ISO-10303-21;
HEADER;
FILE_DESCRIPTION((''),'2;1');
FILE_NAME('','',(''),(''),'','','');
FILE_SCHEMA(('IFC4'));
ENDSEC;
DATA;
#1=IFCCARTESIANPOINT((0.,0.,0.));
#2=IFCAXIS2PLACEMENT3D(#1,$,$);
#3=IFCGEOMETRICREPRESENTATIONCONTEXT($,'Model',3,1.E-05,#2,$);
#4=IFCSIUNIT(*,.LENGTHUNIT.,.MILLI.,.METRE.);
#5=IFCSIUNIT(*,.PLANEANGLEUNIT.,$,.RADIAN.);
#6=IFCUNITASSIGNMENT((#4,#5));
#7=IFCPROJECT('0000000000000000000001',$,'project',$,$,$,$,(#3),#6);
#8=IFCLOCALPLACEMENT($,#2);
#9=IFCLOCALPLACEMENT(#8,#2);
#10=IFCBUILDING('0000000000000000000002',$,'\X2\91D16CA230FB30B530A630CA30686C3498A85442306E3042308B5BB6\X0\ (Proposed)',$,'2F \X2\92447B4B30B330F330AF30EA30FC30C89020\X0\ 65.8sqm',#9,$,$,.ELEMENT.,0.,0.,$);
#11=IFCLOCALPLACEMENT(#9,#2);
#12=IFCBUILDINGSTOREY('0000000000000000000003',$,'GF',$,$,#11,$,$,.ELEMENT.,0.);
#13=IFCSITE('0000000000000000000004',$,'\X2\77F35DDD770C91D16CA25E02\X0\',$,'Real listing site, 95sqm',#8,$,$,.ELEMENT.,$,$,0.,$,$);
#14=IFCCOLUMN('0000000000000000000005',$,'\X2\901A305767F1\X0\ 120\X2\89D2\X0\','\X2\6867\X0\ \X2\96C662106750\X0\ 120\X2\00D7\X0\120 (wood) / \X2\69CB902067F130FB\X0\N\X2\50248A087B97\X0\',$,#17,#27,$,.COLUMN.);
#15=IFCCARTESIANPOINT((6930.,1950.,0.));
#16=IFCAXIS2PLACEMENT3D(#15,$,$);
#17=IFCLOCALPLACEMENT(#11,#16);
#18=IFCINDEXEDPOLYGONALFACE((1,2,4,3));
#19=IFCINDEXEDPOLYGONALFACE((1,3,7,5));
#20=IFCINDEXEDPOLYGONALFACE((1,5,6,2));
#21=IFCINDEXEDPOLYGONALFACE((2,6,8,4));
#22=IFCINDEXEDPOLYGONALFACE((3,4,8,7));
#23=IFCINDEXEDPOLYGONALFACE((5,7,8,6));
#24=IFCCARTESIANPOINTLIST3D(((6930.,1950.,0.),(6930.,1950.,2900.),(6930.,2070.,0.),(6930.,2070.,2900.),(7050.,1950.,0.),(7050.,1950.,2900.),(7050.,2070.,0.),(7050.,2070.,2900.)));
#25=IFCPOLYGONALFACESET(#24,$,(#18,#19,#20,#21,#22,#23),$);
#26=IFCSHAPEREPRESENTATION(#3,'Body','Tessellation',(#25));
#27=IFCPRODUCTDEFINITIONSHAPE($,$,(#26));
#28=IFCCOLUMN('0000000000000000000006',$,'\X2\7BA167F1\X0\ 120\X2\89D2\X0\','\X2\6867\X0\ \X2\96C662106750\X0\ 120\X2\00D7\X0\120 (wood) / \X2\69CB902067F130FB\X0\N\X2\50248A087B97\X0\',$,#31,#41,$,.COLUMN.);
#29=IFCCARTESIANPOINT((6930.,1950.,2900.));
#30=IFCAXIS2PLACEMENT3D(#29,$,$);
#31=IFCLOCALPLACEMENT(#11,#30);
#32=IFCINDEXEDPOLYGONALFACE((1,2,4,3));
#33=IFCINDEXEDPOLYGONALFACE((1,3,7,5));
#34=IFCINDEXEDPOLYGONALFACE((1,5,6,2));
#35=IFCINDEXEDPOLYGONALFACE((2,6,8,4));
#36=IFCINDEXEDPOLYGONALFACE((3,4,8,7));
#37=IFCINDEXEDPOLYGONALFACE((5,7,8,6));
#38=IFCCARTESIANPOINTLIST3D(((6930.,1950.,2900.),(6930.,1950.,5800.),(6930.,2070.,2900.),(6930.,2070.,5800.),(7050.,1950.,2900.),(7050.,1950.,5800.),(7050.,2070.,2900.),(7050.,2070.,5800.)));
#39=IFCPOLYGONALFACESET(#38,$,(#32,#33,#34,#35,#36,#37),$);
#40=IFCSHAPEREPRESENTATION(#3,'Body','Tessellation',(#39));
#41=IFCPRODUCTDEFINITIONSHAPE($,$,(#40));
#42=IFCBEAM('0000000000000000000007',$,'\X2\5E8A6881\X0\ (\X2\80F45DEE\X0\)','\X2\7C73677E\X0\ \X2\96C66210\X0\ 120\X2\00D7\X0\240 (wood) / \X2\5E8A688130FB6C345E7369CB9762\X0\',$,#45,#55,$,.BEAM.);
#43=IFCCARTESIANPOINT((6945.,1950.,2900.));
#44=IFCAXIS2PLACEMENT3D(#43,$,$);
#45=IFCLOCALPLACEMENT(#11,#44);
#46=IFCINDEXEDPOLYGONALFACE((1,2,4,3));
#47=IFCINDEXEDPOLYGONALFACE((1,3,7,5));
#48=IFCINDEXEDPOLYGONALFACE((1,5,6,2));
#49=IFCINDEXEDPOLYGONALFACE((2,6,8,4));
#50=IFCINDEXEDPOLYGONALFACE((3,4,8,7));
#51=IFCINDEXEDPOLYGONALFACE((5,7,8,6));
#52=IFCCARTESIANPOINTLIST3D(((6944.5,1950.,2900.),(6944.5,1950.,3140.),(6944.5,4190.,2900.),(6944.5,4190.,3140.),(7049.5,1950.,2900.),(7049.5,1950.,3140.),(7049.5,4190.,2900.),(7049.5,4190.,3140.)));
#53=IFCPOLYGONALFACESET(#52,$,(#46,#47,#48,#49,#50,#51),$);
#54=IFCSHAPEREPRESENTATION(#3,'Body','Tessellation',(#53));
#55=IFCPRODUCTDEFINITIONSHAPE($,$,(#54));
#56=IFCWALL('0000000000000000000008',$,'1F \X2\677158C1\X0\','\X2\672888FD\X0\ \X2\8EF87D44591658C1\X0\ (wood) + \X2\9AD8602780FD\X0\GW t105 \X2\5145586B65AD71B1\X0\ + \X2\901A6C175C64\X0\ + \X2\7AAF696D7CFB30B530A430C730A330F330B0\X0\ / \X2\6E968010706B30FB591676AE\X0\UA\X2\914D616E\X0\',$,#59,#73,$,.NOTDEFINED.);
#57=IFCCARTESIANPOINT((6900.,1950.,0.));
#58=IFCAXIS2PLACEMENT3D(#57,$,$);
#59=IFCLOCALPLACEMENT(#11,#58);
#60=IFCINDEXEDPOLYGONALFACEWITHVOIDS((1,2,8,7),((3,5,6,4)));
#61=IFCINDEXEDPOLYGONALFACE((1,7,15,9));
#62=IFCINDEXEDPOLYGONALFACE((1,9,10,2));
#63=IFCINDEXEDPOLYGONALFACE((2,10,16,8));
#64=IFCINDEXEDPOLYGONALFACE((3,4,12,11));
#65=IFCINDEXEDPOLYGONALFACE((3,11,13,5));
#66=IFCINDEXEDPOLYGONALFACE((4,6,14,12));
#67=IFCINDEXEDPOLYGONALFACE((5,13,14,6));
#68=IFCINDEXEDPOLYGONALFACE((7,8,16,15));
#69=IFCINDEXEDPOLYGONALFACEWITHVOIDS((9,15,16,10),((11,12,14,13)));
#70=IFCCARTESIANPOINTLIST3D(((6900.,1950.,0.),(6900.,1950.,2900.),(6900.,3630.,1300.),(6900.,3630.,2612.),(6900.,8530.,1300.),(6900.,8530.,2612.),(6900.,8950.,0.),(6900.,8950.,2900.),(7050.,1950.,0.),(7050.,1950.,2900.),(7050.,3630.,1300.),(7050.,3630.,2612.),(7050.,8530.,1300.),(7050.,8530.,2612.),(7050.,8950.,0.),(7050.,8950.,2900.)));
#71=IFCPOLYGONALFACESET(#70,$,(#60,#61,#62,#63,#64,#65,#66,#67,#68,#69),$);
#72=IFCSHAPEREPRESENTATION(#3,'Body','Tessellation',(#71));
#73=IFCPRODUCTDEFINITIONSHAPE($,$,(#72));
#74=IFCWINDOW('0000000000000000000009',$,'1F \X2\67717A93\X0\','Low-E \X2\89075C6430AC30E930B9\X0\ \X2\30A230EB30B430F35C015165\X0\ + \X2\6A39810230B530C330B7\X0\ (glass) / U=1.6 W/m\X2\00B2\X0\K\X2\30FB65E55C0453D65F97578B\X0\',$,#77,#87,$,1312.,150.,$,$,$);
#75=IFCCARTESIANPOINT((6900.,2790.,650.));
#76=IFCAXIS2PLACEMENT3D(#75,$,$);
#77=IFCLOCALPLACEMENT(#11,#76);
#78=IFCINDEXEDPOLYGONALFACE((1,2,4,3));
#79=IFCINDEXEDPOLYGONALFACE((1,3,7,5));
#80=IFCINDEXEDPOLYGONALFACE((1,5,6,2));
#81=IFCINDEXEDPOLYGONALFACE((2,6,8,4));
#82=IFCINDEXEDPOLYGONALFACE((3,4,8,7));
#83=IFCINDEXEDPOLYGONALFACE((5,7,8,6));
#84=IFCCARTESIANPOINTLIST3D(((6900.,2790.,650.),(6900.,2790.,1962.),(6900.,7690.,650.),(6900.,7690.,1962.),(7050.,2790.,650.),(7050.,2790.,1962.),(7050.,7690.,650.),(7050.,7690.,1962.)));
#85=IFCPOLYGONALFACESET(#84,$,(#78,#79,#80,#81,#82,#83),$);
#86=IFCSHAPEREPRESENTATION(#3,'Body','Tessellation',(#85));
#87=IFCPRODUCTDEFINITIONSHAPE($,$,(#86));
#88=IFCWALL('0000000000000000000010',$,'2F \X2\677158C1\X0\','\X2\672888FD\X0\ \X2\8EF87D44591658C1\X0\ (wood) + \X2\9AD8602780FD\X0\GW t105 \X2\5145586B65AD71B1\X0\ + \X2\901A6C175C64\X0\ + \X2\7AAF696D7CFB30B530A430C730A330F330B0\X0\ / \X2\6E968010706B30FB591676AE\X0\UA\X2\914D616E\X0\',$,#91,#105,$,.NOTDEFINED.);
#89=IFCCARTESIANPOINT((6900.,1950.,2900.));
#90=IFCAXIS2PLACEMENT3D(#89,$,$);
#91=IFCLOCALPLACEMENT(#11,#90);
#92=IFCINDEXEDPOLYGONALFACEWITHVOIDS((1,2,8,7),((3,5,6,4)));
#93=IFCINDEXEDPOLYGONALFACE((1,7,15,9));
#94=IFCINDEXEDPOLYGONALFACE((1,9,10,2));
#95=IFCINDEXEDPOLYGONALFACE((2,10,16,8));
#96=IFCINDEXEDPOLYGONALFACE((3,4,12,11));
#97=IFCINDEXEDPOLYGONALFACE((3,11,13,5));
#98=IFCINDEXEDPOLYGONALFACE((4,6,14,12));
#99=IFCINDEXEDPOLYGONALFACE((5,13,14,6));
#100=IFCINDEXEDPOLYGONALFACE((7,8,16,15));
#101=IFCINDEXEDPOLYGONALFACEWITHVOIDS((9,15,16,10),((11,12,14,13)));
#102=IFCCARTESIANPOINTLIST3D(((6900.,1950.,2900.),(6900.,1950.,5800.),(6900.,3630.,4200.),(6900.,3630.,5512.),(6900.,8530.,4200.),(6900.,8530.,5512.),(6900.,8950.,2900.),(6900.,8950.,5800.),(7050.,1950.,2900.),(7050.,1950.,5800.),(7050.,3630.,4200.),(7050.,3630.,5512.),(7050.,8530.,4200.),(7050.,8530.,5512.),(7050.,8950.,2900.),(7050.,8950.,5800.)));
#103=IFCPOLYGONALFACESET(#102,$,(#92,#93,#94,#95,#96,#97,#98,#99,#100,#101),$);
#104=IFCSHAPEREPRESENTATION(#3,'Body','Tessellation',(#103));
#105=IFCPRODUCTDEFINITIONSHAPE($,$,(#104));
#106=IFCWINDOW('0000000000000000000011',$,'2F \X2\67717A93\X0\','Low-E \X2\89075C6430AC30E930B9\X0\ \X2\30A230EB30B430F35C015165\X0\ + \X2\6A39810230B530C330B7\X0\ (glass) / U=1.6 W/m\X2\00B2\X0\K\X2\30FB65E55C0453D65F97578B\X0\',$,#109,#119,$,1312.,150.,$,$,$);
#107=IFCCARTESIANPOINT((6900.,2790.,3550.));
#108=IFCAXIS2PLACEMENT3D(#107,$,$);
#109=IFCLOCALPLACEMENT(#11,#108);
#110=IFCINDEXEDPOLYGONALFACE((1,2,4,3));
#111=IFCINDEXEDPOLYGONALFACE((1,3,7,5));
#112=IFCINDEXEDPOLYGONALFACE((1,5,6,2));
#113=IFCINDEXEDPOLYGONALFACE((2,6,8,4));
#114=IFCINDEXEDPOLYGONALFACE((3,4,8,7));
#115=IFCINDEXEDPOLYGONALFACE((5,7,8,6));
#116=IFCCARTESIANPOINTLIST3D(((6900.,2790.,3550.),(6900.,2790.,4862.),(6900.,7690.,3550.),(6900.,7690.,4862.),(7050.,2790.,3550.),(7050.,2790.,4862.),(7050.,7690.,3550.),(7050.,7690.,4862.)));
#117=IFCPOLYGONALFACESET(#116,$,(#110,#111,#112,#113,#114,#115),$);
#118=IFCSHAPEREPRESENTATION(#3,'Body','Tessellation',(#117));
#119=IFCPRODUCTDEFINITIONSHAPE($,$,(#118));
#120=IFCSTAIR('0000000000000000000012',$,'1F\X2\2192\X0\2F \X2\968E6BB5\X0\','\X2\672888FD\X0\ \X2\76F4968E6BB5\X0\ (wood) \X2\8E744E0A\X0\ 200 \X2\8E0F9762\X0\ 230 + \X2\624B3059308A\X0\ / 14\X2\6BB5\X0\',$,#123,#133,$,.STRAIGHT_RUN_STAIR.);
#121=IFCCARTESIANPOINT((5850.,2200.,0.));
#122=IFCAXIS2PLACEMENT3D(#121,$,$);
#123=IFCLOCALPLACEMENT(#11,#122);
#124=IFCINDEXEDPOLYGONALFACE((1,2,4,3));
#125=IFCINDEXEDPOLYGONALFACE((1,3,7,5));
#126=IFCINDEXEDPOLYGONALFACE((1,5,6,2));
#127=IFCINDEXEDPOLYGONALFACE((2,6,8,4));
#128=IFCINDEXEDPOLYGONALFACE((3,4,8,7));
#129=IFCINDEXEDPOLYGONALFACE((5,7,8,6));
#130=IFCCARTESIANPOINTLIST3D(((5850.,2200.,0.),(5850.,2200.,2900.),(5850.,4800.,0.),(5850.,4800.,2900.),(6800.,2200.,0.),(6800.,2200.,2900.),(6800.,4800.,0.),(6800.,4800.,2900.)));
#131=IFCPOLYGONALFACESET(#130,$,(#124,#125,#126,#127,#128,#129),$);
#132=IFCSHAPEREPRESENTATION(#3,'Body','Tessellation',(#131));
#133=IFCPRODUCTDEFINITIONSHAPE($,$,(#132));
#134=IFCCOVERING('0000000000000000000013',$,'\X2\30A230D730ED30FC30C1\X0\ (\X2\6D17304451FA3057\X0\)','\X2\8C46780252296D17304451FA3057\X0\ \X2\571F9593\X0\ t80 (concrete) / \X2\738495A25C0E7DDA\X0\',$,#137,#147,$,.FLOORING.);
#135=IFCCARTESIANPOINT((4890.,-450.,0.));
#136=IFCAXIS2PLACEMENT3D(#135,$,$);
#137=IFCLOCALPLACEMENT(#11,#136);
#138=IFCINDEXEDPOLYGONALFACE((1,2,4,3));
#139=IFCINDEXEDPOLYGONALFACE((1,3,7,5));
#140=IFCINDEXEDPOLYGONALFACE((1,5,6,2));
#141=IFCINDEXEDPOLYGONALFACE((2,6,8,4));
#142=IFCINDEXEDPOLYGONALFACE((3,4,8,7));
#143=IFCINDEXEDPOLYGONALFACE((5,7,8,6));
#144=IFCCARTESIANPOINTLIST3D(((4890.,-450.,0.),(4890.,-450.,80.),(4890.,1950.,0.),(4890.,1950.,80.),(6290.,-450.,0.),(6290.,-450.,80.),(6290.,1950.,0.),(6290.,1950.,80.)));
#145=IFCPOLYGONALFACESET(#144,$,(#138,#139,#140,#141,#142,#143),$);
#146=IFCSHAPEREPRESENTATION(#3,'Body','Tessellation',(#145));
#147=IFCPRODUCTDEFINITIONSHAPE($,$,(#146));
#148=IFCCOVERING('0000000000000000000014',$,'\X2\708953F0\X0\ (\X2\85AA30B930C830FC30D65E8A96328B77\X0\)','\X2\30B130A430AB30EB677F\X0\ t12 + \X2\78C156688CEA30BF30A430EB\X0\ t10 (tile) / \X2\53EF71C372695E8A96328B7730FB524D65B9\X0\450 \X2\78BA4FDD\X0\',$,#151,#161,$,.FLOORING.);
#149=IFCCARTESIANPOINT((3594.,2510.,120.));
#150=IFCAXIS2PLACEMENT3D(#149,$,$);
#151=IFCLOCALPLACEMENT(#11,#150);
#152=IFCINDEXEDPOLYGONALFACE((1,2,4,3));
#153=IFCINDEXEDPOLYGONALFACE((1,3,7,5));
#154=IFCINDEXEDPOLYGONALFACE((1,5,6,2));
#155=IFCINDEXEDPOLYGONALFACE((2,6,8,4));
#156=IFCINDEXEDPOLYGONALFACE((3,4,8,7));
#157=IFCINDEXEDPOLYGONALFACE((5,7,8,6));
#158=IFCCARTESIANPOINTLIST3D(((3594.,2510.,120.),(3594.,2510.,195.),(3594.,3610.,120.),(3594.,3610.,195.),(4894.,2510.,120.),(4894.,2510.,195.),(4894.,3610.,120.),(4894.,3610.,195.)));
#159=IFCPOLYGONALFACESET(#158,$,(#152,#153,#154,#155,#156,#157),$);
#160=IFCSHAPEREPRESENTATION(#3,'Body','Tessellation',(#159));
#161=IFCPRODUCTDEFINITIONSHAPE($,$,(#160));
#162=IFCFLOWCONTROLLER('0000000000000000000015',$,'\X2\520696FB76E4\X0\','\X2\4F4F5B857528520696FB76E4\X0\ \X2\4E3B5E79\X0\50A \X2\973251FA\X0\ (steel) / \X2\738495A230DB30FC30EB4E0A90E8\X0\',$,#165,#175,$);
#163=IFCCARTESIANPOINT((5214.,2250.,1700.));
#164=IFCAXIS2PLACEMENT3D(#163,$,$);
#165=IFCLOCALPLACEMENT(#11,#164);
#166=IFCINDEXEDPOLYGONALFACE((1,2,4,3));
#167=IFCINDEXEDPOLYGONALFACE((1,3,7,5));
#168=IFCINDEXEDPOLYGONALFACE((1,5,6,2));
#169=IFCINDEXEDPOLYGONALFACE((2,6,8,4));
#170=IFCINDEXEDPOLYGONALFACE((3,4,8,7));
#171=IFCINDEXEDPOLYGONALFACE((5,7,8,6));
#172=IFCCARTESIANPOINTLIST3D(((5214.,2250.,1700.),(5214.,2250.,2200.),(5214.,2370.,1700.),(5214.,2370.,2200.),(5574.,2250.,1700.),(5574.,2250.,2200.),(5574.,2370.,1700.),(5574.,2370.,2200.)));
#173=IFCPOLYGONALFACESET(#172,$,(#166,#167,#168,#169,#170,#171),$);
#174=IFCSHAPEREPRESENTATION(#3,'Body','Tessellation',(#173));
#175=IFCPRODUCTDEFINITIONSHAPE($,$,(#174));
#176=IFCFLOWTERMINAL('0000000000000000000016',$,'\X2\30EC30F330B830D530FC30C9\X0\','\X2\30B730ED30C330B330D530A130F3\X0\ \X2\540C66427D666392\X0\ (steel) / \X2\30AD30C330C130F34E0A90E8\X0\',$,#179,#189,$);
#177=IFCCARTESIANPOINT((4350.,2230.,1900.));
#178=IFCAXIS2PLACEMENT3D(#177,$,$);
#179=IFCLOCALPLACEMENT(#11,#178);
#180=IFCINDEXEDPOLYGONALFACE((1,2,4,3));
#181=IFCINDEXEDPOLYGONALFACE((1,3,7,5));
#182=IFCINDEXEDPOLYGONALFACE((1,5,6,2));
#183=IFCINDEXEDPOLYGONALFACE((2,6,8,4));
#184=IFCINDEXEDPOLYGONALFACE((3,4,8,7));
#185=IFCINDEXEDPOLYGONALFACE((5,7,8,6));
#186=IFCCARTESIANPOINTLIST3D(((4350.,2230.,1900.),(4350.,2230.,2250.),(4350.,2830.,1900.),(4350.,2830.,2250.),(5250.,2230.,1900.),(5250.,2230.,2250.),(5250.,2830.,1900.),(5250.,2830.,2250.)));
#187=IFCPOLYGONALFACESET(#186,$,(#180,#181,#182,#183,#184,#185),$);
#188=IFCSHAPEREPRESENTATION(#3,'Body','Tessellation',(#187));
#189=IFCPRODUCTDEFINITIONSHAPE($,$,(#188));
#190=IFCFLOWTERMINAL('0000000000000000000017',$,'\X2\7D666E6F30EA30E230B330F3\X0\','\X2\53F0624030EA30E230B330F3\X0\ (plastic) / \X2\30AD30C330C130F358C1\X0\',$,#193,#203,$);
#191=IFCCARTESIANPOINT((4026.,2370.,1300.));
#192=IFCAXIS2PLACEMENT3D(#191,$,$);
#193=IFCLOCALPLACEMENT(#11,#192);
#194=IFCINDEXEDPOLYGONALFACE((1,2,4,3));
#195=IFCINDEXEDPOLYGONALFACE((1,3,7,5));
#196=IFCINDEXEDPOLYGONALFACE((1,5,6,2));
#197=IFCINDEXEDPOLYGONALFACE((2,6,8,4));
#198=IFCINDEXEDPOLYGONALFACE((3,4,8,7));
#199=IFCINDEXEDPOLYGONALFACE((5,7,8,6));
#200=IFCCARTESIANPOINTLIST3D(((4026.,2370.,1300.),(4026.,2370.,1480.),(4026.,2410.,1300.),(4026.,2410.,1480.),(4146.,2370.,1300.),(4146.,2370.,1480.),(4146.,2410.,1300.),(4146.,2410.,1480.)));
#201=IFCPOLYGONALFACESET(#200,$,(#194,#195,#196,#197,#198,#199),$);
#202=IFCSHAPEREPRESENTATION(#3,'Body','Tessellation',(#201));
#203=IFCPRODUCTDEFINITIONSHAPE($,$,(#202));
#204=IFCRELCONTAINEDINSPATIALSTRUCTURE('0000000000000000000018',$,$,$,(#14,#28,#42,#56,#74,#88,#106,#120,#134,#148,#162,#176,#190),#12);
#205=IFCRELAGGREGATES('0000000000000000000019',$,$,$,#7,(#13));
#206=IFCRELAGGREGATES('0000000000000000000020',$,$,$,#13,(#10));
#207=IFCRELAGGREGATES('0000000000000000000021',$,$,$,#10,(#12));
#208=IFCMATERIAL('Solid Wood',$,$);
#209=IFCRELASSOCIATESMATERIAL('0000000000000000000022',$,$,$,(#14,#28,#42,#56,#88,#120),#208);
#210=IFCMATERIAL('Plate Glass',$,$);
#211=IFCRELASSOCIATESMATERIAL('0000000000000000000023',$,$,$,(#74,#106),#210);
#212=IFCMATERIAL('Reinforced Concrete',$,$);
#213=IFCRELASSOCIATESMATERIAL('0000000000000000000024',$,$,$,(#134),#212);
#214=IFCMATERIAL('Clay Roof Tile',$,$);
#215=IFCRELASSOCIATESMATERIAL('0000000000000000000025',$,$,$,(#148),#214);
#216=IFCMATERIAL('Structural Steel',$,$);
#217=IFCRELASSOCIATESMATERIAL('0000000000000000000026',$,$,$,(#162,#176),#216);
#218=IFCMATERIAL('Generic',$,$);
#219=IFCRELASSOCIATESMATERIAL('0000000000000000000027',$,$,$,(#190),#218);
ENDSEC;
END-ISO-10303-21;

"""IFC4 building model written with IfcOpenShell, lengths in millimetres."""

from ifc_helpers import new_model, si_unit, frame, frame_2d, origin, place, context, project, spatial, rectangle, extrude, material, element, fill, save


model = new_model("IFC4")

# Units and contexts
model_context = context("Model", 3, precision=1e-05, world=origin())
ifc_project = project(units=[si_unit("LENGTHUNIT", "METRE", prefix="MILLI"), si_unit("PLANEANGLEUNIT", "RADIAN")], contexts=[model_context])

# Site, building, storey
site_placement = place(None, origin())
site = spatial("IfcSite", under=ifc_project, at=site_placement, Name="石川県金沢市", ObjectType="Real listing site, 95sqm", CompositionType="ELEMENT", RefElevation=0.0)
building_placement = place(site_placement, origin())
building = spatial("IfcBuilding", under=site, at=building_placement, Name="金沢・サウナと水風呂のある家 (Proposed)", ObjectType="2F 鉄筋コンクリート造 65.8sqm", CompositionType="ELEMENT", ElevationOfRefHeight=0.0, ElevationOfTerrain=0.0)
storey_placement = place(building_placement, origin())
storey = spatial("IfcBuildingStorey", under=building, at=storey_placement, Name="GF", CompositionType="ELEMENT", Elevation=0.0)

# Columns
ifc_material_1 = material(Name="Solid Wood")
column_1_placement = place(storey_placement, frame((6930.0, 1950.0, 0.0)))
element("IfcColumn", 1, at=column_1_placement, inside=storey, material=ifc_material_1, Name="通し柱 120角", Description="桧 集成材 120×120 (wood) / 構造柱・N値計算", PredefinedType="COLUMN", context=model_context, shape_type="SweptSolid", body=[
    extrude(rectangle(XDim=120.0, YDim=120.0, at=frame_2d((60.0, 60.0))), frame((6930.0, 1950.0, 0.0)), (0.0, 0.0, 1.0), 2900.0),
])
column_2_placement = place(storey_placement, frame((6930.0, 1950.0, 2900.0)))
element("IfcColumn", 2, at=column_2_placement, inside=storey, material=ifc_material_1, Name="管柱 120角", Description="桧 集成材 120×120 (wood) / 構造柱・N値計算", PredefinedType="COLUMN", context=model_context, shape_type="SweptSolid", body=[
    extrude(rectangle(XDim=120.0, YDim=120.0, at=frame_2d((60.0, 60.0))), frame((6930.0, 1950.0, 2900.0)), (0.0, 0.0, 1.0), 2900.0),
])

# Beam
beam_1_placement = place(storey_placement, frame((6945.0, 1950.0, 2900.0)))
element("IfcBeam", 3, at=beam_1_placement, inside=storey, material=ifc_material_1, Name="床梁 (胴差)", Description="米松 集成 120×240 (wood) / 床梁・水平構面", PredefinedType="BEAM", context=model_context, shape_type="SweptSolid", body=[
    extrude(rectangle(XDim=105.0, YDim=2240.0, at=frame_2d((52.0, 1120.0))), frame((6945.0, 1950.0, 2900.0)), (0.0, 0.0, 1.0), 240.0),
])

# Wall, opening, window
wall_1_placement = place(storey_placement, frame((6900.0, 1950.0, 0.0)))
wall_1 = element("IfcWall", 4, at=wall_1_placement, inside=storey, material=ifc_material_1, Name="1F 東壁", Description="木製 軸組外壁 (wood) + 高性能GW t105 充填断熱 + 通気層 + 窯業系サイディング / 準耐火・外皮UA配慮", PredefinedType="NOTDEFINED", context=model_context, shape_type="SweptSolid", body=[
    extrude(rectangle(XDim=150.0, YDim=7000.0, at=frame_2d((75.0, 3500.0))), frame((6900.0, 1950.0, 0.0)), (0.0, 0.0, 1.0), 2900.0),
])
opening_1_placement = place(storey_placement, frame((6900.0, 2790.0, 650.0)))
opening_1 = element("IfcOpeningElement", 5, at=opening_1_placement, cuts=wall_1, PredefinedType="NOTDEFINED", context=model_context, shape_type="SweptSolid", body=[
    extrude(rectangle(XDim=150.0, YDim=4900.0, at=frame_2d((75.0, 2450.0))), frame((6900.0, 2790.0, 650.0)), (0.0, 0.0, 1.0), 1312.0),
])
ifc_material_2 = material(Name="Plate Glass")
window_1_placement = place(storey_placement, frame((6900.0, 2790.0, 650.0)))
window_1 = element("IfcWindow", 6, at=window_1_placement, inside=storey, material=ifc_material_2, Name="1F 東窓", Description="Low-E 複層ガラス アルゴン封入 + 樹脂サッシ (glass) / U=1.6 W/m²K・日射取得型", OverallHeight=1312.0, OverallWidth=150.0, context=model_context, shape_type="SweptSolid", body=[
    extrude(rectangle(XDim=150.0, YDim=4900.0, at=frame_2d((75.0, 2450.0))), frame((6900.0, 2790.0, 650.0)), (0.0, 0.0, 1.0), 1312.0),
])
fill(opening_1, window_1)

# Wall, opening, window
wall_2_placement = place(storey_placement, frame((6900.0, 1950.0, 2900.0)))
wall_2 = element("IfcWall", 7, at=wall_2_placement, inside=storey, material=ifc_material_1, Name="2F 東壁", Description="木製 軸組外壁 (wood) + 高性能GW t105 充填断熱 + 通気層 + 窯業系サイディング / 準耐火・外皮UA配慮", PredefinedType="NOTDEFINED", context=model_context, shape_type="SweptSolid", body=[
    extrude(rectangle(XDim=150.0, YDim=7000.0, at=frame_2d((75.0, 3500.0))), frame((6900.0, 1950.0, 2900.0)), (0.0, 0.0, 1.0), 2900.0),
])
opening_2_placement = place(storey_placement, frame((6900.0, 2790.0, 3550.0)))
opening_2 = element("IfcOpeningElement", 8, at=opening_2_placement, cuts=wall_2, PredefinedType="NOTDEFINED", context=model_context, shape_type="SweptSolid", body=[
    extrude(rectangle(XDim=150.0, YDim=4900.0, at=frame_2d((75.0, 2450.0))), frame((6900.0, 2790.0, 3550.0)), (0.0, 0.0, 1.0), 1312.0),
])
window_2_placement = place(storey_placement, frame((6900.0, 2790.0, 3550.0)))
window_2 = element("IfcWindow", 9, at=window_2_placement, inside=storey, material=ifc_material_2, Name="2F 東窓", Description="Low-E 複層ガラス アルゴン封入 + 樹脂サッシ (glass) / U=1.6 W/m²K・日射取得型", OverallHeight=1312.0, OverallWidth=150.0, context=model_context, shape_type="SweptSolid", body=[
    extrude(rectangle(XDim=150.0, YDim=4900.0, at=frame_2d((75.0, 2450.0))), frame((6900.0, 2790.0, 3550.0)), (0.0, 0.0, 1.0), 1312.0),
])
fill(opening_2, window_2)

# Stair
stair_placement = place(storey_placement, frame((5850.0, 2200.0, 0.0)))
element("IfcStair", 10, at=stair_placement, inside=storey, material=ifc_material_1, Name="1F→2F 階段", Description="木製 直階段 (wood) 蹴上 200 踏面 230 + 手すり / 14段", PredefinedType="STRAIGHT_RUN_STAIR", context=model_context, shape_type="SweptSolid", body=[
    extrude(rectangle(XDim=950.0, YDim=2600.0, at=frame_2d((475.0, 1300.0))), frame((5850.0, 2200.0, 0.0)), (0.0, 0.0, 1.0), 2900.0),
])

# Coverings
ifc_material_3 = material(Name="Reinforced Concrete")
covering_1_placement = place(storey_placement, frame((4890.0, -450.0, 0.0)))
element("IfcCovering", 11, at=covering_1_placement, inside=storey, material=ifc_material_3, Name="アプローチ (洗い出し)", Description="豆砂利洗い出し 土間 t80 (concrete) / 玄関導線", PredefinedType="FLOORING", context=model_context, shape_type="SweptSolid", body=[
    extrude(rectangle(XDim=1400.0, YDim=2400.0, at=frame_2d((700.0, 1200.0))), frame((4890.0, -450.0, 0.0)), (0.0, 0.0, 1.0), 80.0),
])
ifc_material_4 = material(Name="Clay Roof Tile")
covering_2_placement = place(storey_placement, frame((3594.0, 2510.0, 120.0)))
element("IfcCovering", 12, at=covering_2_placement, inside=storey, material=ifc_material_4, Name="炉台 (薪ストーブ床防護)", Description="ケイカル板 t12 + 磁器質タイル t10 (tile) / 可燃物床防護・前方450 確保", PredefinedType="FLOORING", context=model_context, shape_type="SweptSolid", body=[
    extrude(rectangle(XDim=1300.0, YDim=1100.0, at=frame_2d((650.0, 550.0))), frame((3594.0, 2510.0, 120.0)), (0.0, 0.0, 1.0), 75.0),
])

# Flow controller
ifc_material_5 = material(Name="Structural Steel")
flow_controller_placement = place(storey_placement, frame((5214.0, 2250.0, 1700.0)))
element("IfcFlowController", 13, at=flow_controller_placement, inside=storey, material=ifc_material_5, Name="分電盤", Description="住宅用分電盤 主幹50A 露出 (steel) / 玄関ホール上部", context=model_context, shape_type="SweptSolid", body=[
    extrude(rectangle(XDim=360.0, YDim=120.0, at=frame_2d((180.0, 60.0))), frame((5214.0, 2250.0, 1700.0)), (0.0, 0.0, 1.0), 500.0),
])

# Flow terminals
flow_terminal_1_placement = place(storey_placement, frame((4350.0, 2230.0, 1900.0)))
element("IfcFlowTerminal", 14, at=flow_terminal_1_placement, inside=storey, material=ifc_material_5, Name="レンジフード", Description="シロッコファン 同時給排 (steel) / キッチン上部", context=model_context, shape_type="SweptSolid", body=[
    extrude(rectangle(XDim=900.0, YDim=600.0, at=frame_2d((450.0, 300.0))), frame((4350.0, 2230.0, 1900.0)), (0.0, 0.0, 1.0), 350.0),
])
ifc_material_6 = material(Name="Generic")
flow_terminal_2_placement = place(storey_placement, frame((4026.0, 2370.0, 1300.0)))
element("IfcFlowTerminal", 15, at=flow_terminal_2_placement, inside=storey, material=ifc_material_6, Name="給湯リモコン", Description="台所リモコン (plastic) / キッチン壁", context=model_context, shape_type="SweptSolid", body=[
    extrude(rectangle(XDim=120.0, YDim=40.0, at=frame_2d((60.0, 20.0))), frame((4026.0, 2370.0, 1300.0)), (0.0, 0.0, 1.0), 180.0),
])

save(model, "model.ifc")
